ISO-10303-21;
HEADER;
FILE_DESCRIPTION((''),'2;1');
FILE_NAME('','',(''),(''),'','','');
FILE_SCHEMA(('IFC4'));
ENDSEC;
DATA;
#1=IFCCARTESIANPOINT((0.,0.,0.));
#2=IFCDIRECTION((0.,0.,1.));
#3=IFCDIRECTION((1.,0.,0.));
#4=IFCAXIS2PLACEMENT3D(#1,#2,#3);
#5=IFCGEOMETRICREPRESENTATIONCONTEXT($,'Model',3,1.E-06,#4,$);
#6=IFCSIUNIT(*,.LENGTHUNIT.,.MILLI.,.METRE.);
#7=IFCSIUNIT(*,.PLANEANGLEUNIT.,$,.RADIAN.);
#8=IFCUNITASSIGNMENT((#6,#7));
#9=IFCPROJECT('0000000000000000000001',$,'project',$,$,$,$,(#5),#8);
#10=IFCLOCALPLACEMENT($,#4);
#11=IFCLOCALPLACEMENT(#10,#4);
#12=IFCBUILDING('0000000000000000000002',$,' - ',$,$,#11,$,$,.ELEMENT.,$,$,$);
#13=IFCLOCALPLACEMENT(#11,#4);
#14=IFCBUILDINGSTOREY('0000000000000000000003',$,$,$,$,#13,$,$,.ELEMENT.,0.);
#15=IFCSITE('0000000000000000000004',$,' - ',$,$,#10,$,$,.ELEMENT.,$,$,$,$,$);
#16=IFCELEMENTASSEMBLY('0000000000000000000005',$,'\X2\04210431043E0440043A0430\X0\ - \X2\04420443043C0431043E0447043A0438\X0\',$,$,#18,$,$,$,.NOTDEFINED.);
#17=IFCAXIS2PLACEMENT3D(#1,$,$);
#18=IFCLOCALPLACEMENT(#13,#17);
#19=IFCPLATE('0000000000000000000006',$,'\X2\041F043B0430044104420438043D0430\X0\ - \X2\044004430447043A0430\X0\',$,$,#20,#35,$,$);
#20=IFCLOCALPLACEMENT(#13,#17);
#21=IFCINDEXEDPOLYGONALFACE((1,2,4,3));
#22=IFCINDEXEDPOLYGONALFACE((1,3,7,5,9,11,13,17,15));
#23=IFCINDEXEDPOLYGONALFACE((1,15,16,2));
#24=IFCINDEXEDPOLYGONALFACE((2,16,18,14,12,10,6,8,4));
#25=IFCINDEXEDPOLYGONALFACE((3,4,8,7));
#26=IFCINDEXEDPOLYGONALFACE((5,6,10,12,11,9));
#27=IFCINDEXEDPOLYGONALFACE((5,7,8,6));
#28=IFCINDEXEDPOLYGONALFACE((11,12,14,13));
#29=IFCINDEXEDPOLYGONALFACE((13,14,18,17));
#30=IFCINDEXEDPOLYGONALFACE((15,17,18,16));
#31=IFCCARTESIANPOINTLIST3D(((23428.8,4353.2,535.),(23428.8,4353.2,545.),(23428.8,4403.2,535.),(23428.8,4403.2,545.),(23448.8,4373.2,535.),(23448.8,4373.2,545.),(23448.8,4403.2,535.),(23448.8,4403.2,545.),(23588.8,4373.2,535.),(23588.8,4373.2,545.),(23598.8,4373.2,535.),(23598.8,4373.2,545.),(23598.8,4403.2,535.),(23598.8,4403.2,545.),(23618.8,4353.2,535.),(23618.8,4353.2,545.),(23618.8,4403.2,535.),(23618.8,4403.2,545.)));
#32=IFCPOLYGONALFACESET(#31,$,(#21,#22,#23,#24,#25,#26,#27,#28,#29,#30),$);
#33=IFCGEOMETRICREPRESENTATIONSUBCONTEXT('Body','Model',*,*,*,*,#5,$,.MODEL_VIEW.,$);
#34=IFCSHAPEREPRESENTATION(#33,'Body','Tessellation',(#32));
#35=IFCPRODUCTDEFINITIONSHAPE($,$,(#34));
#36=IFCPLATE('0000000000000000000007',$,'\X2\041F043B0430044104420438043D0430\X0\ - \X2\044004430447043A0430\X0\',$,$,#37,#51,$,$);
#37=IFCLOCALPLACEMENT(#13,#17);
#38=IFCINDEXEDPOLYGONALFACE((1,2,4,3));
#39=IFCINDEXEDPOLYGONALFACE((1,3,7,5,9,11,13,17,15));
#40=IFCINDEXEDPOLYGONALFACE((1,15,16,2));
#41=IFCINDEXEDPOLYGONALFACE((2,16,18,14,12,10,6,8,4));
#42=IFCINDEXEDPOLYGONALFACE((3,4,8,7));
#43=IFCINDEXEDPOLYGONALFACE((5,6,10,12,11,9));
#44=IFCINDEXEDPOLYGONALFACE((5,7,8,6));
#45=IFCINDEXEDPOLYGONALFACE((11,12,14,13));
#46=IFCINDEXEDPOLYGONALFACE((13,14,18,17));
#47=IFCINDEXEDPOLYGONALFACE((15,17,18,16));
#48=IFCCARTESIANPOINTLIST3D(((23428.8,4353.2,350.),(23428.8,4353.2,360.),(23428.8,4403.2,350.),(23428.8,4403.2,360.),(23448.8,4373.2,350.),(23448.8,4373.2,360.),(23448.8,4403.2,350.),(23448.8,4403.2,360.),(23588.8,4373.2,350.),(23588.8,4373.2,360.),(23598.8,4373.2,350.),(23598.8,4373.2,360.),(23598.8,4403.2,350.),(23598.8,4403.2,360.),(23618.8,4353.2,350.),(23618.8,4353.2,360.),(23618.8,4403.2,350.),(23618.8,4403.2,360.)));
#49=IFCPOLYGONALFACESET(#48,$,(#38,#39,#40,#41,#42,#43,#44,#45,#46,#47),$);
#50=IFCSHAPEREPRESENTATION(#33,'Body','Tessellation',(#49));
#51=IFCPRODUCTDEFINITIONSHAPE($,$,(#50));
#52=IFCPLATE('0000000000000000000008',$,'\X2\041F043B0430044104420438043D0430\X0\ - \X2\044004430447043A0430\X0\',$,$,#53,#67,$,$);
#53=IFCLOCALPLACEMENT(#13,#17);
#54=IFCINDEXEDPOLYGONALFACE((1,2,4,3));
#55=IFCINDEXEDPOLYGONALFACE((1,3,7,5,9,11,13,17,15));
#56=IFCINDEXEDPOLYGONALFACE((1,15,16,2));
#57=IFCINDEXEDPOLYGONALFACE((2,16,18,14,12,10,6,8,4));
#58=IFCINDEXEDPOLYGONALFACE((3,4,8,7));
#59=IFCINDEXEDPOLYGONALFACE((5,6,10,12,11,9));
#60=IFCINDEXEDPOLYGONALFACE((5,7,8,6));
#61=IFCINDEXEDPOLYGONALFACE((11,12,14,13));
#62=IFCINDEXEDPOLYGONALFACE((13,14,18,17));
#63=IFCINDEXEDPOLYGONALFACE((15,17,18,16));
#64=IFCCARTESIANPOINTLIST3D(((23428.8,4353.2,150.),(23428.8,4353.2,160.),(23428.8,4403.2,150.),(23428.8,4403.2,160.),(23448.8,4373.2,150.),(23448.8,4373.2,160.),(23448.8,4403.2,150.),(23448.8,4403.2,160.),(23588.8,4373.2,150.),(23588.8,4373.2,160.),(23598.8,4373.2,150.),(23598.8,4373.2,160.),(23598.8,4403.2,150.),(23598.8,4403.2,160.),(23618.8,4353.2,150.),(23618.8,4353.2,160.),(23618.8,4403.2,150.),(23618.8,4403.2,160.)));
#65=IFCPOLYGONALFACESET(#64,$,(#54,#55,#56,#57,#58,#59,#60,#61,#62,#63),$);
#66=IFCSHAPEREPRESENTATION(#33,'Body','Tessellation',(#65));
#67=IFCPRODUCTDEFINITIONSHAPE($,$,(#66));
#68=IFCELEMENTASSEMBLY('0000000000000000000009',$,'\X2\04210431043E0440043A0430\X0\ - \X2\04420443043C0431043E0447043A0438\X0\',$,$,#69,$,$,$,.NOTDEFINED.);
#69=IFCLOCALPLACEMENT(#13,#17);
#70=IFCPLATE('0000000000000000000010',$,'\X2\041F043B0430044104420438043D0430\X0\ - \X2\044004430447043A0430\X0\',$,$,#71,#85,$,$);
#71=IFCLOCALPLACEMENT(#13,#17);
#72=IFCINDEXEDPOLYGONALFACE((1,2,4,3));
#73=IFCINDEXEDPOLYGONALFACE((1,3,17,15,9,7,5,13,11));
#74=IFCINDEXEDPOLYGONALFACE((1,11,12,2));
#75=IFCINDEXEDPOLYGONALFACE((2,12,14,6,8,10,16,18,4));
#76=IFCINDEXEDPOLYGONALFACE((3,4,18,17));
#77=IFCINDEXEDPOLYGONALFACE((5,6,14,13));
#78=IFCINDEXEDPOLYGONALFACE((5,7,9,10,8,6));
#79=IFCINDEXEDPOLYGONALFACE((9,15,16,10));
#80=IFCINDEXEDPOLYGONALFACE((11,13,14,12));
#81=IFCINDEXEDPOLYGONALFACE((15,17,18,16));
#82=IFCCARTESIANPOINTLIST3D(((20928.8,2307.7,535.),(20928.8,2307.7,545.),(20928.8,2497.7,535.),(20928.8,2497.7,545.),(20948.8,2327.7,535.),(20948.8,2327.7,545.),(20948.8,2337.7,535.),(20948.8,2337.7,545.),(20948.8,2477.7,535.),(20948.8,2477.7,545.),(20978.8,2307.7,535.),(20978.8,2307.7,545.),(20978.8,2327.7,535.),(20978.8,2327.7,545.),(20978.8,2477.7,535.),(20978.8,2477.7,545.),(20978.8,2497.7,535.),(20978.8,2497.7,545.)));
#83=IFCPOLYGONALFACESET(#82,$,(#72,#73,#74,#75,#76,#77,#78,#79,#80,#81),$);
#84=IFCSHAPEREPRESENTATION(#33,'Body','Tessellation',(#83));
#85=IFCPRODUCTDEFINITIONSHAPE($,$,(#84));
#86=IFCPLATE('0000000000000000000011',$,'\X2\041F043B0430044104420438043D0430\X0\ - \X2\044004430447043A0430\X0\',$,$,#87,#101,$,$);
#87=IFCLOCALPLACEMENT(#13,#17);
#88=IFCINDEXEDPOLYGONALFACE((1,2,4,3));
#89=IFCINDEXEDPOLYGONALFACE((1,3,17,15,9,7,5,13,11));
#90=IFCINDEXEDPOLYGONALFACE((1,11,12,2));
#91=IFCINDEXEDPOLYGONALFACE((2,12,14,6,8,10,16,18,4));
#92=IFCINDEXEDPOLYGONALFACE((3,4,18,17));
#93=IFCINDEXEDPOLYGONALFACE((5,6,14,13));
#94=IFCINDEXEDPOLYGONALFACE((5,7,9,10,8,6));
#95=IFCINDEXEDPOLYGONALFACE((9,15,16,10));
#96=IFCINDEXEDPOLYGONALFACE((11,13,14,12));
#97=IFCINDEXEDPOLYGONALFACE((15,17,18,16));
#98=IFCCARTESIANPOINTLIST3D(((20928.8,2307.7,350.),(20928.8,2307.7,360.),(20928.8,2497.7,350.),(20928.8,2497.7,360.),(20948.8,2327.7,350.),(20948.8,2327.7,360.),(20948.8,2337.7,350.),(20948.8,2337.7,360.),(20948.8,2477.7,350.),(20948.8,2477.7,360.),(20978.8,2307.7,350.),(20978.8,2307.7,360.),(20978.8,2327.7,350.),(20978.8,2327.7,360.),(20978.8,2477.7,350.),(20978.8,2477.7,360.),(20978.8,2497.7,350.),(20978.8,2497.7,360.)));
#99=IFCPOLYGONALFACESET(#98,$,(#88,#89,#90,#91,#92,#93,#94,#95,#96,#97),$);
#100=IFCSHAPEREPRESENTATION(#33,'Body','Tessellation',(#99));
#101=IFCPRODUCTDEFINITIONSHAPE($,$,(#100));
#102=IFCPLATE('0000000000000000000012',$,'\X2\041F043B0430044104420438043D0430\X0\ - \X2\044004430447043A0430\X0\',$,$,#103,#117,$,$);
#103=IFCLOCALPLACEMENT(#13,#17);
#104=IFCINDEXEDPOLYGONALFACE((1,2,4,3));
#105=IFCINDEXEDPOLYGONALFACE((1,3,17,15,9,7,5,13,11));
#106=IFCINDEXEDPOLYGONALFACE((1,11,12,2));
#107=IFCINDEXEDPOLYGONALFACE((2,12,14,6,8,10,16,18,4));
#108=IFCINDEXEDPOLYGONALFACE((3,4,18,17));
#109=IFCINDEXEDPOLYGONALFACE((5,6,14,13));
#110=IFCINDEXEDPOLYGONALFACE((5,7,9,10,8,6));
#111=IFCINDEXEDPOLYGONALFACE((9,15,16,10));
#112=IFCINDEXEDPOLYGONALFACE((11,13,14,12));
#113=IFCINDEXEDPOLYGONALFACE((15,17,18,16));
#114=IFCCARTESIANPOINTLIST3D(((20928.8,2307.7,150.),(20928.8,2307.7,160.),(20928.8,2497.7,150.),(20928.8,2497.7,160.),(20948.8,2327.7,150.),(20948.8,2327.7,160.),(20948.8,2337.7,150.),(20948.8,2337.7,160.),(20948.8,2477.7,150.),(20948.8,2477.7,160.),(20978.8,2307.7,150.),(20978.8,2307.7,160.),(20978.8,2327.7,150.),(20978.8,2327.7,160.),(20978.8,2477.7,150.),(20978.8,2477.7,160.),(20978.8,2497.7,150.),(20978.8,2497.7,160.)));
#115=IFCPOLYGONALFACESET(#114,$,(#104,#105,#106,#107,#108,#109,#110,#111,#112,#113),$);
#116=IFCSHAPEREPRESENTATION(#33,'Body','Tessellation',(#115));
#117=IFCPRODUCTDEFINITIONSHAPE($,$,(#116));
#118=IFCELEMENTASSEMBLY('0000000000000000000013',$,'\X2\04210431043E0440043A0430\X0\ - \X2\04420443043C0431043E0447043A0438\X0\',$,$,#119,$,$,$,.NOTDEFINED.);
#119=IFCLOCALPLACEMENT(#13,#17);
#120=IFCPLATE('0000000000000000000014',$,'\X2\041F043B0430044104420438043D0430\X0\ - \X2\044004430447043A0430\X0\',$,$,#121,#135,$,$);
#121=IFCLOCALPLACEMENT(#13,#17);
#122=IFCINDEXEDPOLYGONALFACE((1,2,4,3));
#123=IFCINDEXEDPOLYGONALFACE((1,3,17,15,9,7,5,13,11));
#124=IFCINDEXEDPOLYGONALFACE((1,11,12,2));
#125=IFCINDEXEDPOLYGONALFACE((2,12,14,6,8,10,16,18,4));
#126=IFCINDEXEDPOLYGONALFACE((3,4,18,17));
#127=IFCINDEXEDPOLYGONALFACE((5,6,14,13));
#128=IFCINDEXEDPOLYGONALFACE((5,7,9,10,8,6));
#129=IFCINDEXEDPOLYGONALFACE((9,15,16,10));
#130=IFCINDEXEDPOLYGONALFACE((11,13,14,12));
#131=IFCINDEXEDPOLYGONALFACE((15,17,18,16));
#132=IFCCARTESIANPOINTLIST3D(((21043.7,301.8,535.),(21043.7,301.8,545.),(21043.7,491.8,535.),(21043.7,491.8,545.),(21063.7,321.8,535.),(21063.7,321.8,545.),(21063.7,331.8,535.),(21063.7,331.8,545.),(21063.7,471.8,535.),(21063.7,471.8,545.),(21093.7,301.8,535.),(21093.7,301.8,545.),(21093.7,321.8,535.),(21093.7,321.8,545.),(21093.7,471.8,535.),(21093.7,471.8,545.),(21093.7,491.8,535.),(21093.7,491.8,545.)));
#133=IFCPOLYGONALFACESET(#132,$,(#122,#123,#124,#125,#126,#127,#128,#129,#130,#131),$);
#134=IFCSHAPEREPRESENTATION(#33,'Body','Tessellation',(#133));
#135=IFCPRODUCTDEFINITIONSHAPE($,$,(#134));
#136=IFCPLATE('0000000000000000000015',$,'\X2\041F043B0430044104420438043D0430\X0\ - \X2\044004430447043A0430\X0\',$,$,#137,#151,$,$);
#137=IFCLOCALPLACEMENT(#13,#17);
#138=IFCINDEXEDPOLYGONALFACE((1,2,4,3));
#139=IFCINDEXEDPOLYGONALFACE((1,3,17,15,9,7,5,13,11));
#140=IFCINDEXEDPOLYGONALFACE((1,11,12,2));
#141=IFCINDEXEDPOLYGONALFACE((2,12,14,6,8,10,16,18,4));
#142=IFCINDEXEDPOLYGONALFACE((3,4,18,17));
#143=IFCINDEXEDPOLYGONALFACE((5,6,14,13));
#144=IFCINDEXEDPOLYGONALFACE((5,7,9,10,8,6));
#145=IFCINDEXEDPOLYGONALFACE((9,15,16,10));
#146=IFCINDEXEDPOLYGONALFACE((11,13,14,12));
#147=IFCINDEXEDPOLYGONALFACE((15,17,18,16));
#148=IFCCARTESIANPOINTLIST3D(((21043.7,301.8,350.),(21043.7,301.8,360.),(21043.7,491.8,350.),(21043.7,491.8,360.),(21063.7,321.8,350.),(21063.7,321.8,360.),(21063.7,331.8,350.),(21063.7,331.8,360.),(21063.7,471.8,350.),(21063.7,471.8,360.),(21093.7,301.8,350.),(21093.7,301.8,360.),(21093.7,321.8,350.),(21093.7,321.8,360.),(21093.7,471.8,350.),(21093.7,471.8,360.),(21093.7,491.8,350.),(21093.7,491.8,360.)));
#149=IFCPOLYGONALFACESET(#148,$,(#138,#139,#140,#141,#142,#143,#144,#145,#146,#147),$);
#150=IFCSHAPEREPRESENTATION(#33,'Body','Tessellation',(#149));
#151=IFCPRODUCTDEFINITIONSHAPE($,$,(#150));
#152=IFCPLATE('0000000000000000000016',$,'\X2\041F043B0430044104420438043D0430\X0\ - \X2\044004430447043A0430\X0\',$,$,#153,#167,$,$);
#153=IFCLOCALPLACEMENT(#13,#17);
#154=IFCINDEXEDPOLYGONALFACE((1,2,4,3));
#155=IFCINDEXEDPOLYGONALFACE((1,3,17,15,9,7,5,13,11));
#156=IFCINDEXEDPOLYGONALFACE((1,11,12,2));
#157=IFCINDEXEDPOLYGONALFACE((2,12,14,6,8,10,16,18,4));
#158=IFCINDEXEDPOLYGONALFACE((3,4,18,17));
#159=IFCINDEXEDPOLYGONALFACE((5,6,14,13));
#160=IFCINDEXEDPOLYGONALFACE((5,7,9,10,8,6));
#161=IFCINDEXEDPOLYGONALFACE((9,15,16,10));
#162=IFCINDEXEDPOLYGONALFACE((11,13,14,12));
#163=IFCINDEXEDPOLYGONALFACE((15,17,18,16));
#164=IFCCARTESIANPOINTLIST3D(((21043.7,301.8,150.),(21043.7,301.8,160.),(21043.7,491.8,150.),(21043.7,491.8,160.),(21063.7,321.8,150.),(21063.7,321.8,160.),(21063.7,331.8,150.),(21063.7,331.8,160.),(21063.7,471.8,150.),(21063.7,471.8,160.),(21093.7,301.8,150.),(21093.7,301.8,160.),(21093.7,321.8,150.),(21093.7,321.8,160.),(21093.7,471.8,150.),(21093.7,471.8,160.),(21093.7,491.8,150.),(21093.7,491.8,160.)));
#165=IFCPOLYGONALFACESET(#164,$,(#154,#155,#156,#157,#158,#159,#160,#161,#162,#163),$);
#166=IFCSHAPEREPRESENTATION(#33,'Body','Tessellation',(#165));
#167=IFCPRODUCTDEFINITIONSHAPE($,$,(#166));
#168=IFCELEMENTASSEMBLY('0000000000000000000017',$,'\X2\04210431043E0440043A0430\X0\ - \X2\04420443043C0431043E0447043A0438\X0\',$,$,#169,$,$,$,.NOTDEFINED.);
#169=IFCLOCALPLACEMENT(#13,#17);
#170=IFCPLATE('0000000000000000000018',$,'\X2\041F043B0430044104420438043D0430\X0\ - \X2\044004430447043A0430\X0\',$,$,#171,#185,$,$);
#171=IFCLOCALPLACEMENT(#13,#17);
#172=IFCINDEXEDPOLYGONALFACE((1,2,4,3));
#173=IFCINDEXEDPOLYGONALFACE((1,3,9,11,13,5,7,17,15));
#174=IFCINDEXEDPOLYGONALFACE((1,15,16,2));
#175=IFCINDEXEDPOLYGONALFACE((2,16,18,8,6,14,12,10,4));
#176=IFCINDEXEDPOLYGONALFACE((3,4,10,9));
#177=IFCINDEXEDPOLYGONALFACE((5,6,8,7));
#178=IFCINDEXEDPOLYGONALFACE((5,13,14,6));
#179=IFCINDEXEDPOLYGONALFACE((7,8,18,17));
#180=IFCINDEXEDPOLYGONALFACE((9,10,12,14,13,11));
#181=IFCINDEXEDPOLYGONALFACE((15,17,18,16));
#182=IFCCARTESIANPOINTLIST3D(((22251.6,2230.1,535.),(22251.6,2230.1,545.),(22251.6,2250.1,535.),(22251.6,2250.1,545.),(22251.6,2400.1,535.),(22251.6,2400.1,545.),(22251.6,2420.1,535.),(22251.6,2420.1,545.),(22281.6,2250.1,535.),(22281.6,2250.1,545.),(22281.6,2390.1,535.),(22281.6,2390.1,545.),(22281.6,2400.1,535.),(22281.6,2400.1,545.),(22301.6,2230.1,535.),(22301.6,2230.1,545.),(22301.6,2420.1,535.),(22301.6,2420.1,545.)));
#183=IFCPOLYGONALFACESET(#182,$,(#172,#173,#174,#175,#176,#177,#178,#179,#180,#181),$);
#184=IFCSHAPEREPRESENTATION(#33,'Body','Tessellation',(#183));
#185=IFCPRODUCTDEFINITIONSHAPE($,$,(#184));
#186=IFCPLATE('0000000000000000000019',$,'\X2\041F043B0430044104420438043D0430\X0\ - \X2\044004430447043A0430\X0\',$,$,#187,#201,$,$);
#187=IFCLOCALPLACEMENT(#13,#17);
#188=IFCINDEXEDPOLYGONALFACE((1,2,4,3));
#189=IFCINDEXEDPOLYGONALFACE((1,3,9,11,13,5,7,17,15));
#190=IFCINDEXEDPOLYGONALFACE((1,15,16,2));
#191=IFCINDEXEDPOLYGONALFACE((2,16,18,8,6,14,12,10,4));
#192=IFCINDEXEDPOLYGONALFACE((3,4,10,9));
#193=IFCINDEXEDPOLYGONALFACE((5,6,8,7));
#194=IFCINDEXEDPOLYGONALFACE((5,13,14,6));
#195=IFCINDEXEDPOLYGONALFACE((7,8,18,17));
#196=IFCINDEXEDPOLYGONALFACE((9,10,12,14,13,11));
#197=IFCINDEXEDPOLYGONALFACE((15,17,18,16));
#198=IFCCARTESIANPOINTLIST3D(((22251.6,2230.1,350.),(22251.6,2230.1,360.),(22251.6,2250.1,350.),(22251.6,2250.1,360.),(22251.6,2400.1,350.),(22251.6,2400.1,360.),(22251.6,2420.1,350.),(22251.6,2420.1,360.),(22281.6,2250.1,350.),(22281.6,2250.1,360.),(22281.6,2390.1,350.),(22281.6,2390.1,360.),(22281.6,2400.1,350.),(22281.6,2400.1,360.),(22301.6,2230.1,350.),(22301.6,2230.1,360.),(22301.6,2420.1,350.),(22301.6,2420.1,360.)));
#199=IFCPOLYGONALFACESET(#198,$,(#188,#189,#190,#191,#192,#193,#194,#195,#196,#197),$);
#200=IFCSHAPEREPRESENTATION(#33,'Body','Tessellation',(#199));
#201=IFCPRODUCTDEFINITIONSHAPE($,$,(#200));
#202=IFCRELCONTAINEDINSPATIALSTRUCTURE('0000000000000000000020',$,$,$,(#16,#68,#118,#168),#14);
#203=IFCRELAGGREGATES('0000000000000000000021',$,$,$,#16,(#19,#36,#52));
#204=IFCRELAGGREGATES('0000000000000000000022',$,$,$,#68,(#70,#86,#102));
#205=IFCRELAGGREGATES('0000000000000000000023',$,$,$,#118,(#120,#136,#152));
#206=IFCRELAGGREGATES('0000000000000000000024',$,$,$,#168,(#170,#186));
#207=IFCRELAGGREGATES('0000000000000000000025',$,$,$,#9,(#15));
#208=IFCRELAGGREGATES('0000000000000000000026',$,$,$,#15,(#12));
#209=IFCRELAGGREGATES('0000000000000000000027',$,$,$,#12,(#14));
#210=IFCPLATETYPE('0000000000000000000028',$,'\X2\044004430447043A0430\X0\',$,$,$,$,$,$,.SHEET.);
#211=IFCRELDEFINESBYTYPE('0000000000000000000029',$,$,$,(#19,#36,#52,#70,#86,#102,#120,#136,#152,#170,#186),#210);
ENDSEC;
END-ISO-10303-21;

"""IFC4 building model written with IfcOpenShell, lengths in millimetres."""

from ifc_helpers import new_model, si_unit, frame, origin_with_axes, place, context, subcontext, project, spatial, line, indexed_curve, outline, extrude, source, transform, mapped, type_object, element, aggregate, save


model = new_model("IFC4")

# Units and contexts
model_context = context("Model", 3, precision=1e-06, world=origin_with_axes())
body_context = subcontext(model_context, "Body", "Model", "MODEL_VIEW")
ifc_project = project(units=[si_unit("LENGTHUNIT", "METRE", prefix="MILLI"), si_unit("PLANEANGLEUNIT", "RADIAN")], contexts=[model_context])

# Site, building, storey
site_placement = place(None, origin_with_axes())
site = spatial("IfcSite", under=ifc_project, at=site_placement, Name=" - ", CompositionType="ELEMENT")
building_placement = place(site_placement, origin_with_axes())
building = spatial("IfcBuilding", under=site, at=building_placement, Name=" - ", CompositionType="ELEMENT")
storey_placement = place(building_placement, origin_with_axes())
storey = spatial("IfcBuildingStorey", under=building, at=storey_placement, CompositionType="ELEMENT", Elevation=0.0)

# Shared definitions
plate_type = type_object("IfcPlateType", Name="ручка", PredefinedType="SHEET")
shared_shape = source(origin_with_axes(), body_context, "Body", "SweptSolid", [
    extrude(outline(indexed_curve([(-95.0, -25.0), (-75.0, -25.0), (-75.0, 5.0), (-65.0, 5.0), (75.0, 5.0), (75.0, -25.0), (95.0, -25.0), (95.0, 25.0), (-95.0, 25.0)], segments=[line(1, 2), line(2, 3), line(3, 4), line(4, 5), line(5, 6), line(6, 7), line(7, 8), line(8, 9), line(9, 1)])), origin_with_axes(), (0.0, 0.0, 1.0), 10.0),
])

# Element assemblies, plates
assembly_1_placement = place(storey_placement, frame((23323.8, 4403.2, 0.0), z_axis=(0.0, 0.0, 1.0), x_axis=(1.0, 0.0, 0.0)))
assembly_1 = element("IfcElementAssembly", 1, at=assembly_1_placement, inside=storey, Name="Сборка - тумбочки", PredefinedType="NOTDEFINED")
plate_1_placement = place(assembly_1_placement, frame((200.0, -25.0, 535.0), z_axis=(0.0, 0.0, 1.0), x_axis=(-1.0, 0.0, 0.0)))
plate_1 = element("IfcPlate", 2, at=plate_1_placement, type_object=plate_type, Name="Пластина - ручка", context=body_context, shape_type="MappedRepresentation", body=[
    mapped(shared_shape, transform((0.0, 0.0, 0.0), x_axis=(1.0, 0.0, 0.0), y_axis=(0.0, 1.0, 0.0), z_axis=(0.0, 0.0, 1.0), scale=1.0)),
])
plate_2_placement = place(assembly_1_placement, frame((200.0, -25.0, 350.0), z_axis=(0.0, 0.0, 1.0), x_axis=(-1.0, 0.0, 0.0)))
plate_2 = element("IfcPlate", 3, at=plate_2_placement, type_object=plate_type, Name="Пластина - ручка", context=body_context, shape_type="MappedRepresentation", body=[
    mapped(shared_shape, transform((0.0, 0.0, 0.0), x_axis=(1.0, 0.0, 0.0), y_axis=(0.0, 1.0, 0.0), z_axis=(0.0, 0.0, 1.0), scale=1.0)),
])
plate_3_placement = place(assembly_1_placement, frame((200.0, -25.0, 150.0), z_axis=(0.0, 0.0, 1.0), x_axis=(-1.0, 0.0, 0.0)))
plate_3 = element("IfcPlate", 4, at=plate_3_placement, type_object=plate_type, Name="Пластина - ручка", context=body_context, shape_type="MappedRepresentation", body=[
    mapped(shared_shape, transform((0.0, 0.0, 0.0), x_axis=(1.0, 0.0, 0.0), y_axis=(0.0, 1.0, 0.0), z_axis=(0.0, 0.0, 1.0), scale=1.0)),
])
aggregate(assembly_1, [plate_1, plate_2, plate_3])
assembly_2_placement = place(storey_placement, frame((20978.8, 2602.7, 0.0), z_axis=(0.0, 0.0, 1.0), x_axis=(0.0, -1.0, 0.0)))
assembly_2 = element("IfcElementAssembly", 5, at=assembly_2_placement, inside=storey, Name="Сборка - тумбочки", PredefinedType="NOTDEFINED")
plate_4_placement = place(assembly_2_placement, frame((200.0, -25.0, 535.0), z_axis=(0.0, 0.0, 1.0), x_axis=(-1.0, 0.0, 0.0)))
plate_4 = element("IfcPlate", 6, at=plate_4_placement, type_object=plate_type, Name="Пластина - ручка", context=body_context, shape_type="MappedRepresentation", body=[
    mapped(shared_shape, transform((0.0, 0.0, 0.0), x_axis=(1.0, 0.0, 0.0), y_axis=(0.0, 1.0, 0.0), z_axis=(0.0, 0.0, 1.0), scale=1.0)),
])
plate_5_placement = place(assembly_2_placement, frame((200.0, -25.0, 350.0), z_axis=(0.0, 0.0, 1.0), x_axis=(-1.0, 0.0, 0.0)))
plate_5 = element("IfcPlate", 7, at=plate_5_placement, type_object=plate_type, Name="Пластина - ручка", context=body_context, shape_type="MappedRepresentation", body=[
    mapped(shared_shape, transform((0.0, 0.0, 0.0), x_axis=(1.0, 0.0, 0.0), y_axis=(0.0, 1.0, 0.0), z_axis=(0.0, 0.0, 1.0), scale=1.0)),
])
plate_6_placement = place(assembly_2_placement, frame((200.0, -25.0, 150.0), z_axis=(0.0, 0.0, 1.0), x_axis=(-1.0, 0.0, 0.0)))
plate_6 = element("IfcPlate", 8, at=plate_6_placement, type_object=plate_type, Name="Пластина - ручка", context=body_context, shape_type="MappedRepresentation", body=[
    mapped(shared_shape, transform((0.0, 0.0, 0.0), x_axis=(1.0, 0.0, 0.0), y_axis=(0.0, 1.0, 0.0), z_axis=(0.0, 0.0, 1.0), scale=1.0)),
])
aggregate(assembly_2, [plate_4, plate_5, plate_6])
assembly_3_placement = place(storey_placement, frame((21093.7, 596.8, 0.0), z_axis=(0.0, 0.0, 1.0), x_axis=(0.0, -1.0, 0.0)))
assembly_3 = element("IfcElementAssembly", 9, at=assembly_3_placement, inside=storey, Name="Сборка - тумбочки", PredefinedType="NOTDEFINED")
plate_7_placement = place(assembly_3_placement, frame((200.0, -25.0, 535.0), z_axis=(0.0, 0.0, 1.0), x_axis=(-1.0, 0.0, 0.0)))
plate_7 = element("IfcPlate", 10, at=plate_7_placement, type_object=plate_type, Name="Пластина - ручка", context=body_context, shape_type="MappedRepresentation", body=[
    mapped(shared_shape, transform((0.0, 0.0, 0.0), x_axis=(1.0, 0.0, 0.0), y_axis=(0.0, 1.0, 0.0), z_axis=(0.0, 0.0, 1.0), scale=1.0)),
])
plate_8_placement = place(assembly_3_placement, frame((200.0, -25.0, 350.0), z_axis=(0.0, 0.0, 1.0), x_axis=(-1.0, 0.0, 0.0)))
plate_8 = element("IfcPlate", 11, at=plate_8_placement, type_object=plate_type, Name="Пластина - ручка", context=body_context, shape_type="MappedRepresentation", body=[
    mapped(shared_shape, transform((0.0, 0.0, 0.0), x_axis=(1.0, 0.0, 0.0), y_axis=(0.0, 1.0, 0.0), z_axis=(0.0, 0.0, 1.0), scale=1.0)),
])
plate_9_placement = place(assembly_3_placement, frame((200.0, -25.0, 150.0), z_axis=(0.0, 0.0, 1.0), x_axis=(-1.0, 0.0, 0.0)))
plate_9 = element("IfcPlate", 12, at=plate_9_placement, type_object=plate_type, Name="Пластина - ручка", context=body_context, shape_type="MappedRepresentation", body=[
    mapped(shared_shape, transform((0.0, 0.0, 0.0), x_axis=(1.0, 0.0, 0.0), y_axis=(0.0, 1.0, 0.0), z_axis=(0.0, 0.0, 1.0), scale=1.0)),
])
aggregate(assembly_3, [plate_7, plate_8, plate_9])
assembly_4_placement = place(storey_placement, frame((22251.6, 2125.1, 0.0), z_axis=(0.0, 0.0, 1.0), x_axis=(0.0, 1.0, 0.0)))
assembly_4 = element("IfcElementAssembly", 13, at=assembly_4_placement, inside=storey, Name="Сборка - тумбочки", PredefinedType="NOTDEFINED")
plate_10_placement = place(assembly_4_placement, frame((200.0, -25.0, 535.0), z_axis=(0.0, 0.0, 1.0), x_axis=(-1.0, 0.0, 0.0)))
plate_10 = element("IfcPlate", 14, at=plate_10_placement, type_object=plate_type, Name="Пластина - ручка", context=body_context, shape_type="MappedRepresentation", body=[
    mapped(shared_shape, transform((0.0, 0.0, 0.0), x_axis=(1.0, 0.0, 0.0), y_axis=(0.0, 1.0, 0.0), z_axis=(0.0, 0.0, 1.0), scale=1.0)),
])
plate_11_placement = place(assembly_4_placement, frame((200.0, -25.0, 350.0), z_axis=(0.0, 0.0, 1.0), x_axis=(-1.0, 0.0, 0.0)))
plate_11 = element("IfcPlate", 15, at=plate_11_placement, type_object=plate_type, Name="Пластина - ручка", context=body_context, shape_type="MappedRepresentation", body=[
    mapped(shared_shape, transform((0.0, 0.0, 0.0), x_axis=(1.0, 0.0, 0.0), y_axis=(0.0, 1.0, 0.0), z_axis=(0.0, 0.0, 1.0), scale=1.0)),
])
aggregate(assembly_4, [plate_10, plate_11])

save(model, "model.ifc")
